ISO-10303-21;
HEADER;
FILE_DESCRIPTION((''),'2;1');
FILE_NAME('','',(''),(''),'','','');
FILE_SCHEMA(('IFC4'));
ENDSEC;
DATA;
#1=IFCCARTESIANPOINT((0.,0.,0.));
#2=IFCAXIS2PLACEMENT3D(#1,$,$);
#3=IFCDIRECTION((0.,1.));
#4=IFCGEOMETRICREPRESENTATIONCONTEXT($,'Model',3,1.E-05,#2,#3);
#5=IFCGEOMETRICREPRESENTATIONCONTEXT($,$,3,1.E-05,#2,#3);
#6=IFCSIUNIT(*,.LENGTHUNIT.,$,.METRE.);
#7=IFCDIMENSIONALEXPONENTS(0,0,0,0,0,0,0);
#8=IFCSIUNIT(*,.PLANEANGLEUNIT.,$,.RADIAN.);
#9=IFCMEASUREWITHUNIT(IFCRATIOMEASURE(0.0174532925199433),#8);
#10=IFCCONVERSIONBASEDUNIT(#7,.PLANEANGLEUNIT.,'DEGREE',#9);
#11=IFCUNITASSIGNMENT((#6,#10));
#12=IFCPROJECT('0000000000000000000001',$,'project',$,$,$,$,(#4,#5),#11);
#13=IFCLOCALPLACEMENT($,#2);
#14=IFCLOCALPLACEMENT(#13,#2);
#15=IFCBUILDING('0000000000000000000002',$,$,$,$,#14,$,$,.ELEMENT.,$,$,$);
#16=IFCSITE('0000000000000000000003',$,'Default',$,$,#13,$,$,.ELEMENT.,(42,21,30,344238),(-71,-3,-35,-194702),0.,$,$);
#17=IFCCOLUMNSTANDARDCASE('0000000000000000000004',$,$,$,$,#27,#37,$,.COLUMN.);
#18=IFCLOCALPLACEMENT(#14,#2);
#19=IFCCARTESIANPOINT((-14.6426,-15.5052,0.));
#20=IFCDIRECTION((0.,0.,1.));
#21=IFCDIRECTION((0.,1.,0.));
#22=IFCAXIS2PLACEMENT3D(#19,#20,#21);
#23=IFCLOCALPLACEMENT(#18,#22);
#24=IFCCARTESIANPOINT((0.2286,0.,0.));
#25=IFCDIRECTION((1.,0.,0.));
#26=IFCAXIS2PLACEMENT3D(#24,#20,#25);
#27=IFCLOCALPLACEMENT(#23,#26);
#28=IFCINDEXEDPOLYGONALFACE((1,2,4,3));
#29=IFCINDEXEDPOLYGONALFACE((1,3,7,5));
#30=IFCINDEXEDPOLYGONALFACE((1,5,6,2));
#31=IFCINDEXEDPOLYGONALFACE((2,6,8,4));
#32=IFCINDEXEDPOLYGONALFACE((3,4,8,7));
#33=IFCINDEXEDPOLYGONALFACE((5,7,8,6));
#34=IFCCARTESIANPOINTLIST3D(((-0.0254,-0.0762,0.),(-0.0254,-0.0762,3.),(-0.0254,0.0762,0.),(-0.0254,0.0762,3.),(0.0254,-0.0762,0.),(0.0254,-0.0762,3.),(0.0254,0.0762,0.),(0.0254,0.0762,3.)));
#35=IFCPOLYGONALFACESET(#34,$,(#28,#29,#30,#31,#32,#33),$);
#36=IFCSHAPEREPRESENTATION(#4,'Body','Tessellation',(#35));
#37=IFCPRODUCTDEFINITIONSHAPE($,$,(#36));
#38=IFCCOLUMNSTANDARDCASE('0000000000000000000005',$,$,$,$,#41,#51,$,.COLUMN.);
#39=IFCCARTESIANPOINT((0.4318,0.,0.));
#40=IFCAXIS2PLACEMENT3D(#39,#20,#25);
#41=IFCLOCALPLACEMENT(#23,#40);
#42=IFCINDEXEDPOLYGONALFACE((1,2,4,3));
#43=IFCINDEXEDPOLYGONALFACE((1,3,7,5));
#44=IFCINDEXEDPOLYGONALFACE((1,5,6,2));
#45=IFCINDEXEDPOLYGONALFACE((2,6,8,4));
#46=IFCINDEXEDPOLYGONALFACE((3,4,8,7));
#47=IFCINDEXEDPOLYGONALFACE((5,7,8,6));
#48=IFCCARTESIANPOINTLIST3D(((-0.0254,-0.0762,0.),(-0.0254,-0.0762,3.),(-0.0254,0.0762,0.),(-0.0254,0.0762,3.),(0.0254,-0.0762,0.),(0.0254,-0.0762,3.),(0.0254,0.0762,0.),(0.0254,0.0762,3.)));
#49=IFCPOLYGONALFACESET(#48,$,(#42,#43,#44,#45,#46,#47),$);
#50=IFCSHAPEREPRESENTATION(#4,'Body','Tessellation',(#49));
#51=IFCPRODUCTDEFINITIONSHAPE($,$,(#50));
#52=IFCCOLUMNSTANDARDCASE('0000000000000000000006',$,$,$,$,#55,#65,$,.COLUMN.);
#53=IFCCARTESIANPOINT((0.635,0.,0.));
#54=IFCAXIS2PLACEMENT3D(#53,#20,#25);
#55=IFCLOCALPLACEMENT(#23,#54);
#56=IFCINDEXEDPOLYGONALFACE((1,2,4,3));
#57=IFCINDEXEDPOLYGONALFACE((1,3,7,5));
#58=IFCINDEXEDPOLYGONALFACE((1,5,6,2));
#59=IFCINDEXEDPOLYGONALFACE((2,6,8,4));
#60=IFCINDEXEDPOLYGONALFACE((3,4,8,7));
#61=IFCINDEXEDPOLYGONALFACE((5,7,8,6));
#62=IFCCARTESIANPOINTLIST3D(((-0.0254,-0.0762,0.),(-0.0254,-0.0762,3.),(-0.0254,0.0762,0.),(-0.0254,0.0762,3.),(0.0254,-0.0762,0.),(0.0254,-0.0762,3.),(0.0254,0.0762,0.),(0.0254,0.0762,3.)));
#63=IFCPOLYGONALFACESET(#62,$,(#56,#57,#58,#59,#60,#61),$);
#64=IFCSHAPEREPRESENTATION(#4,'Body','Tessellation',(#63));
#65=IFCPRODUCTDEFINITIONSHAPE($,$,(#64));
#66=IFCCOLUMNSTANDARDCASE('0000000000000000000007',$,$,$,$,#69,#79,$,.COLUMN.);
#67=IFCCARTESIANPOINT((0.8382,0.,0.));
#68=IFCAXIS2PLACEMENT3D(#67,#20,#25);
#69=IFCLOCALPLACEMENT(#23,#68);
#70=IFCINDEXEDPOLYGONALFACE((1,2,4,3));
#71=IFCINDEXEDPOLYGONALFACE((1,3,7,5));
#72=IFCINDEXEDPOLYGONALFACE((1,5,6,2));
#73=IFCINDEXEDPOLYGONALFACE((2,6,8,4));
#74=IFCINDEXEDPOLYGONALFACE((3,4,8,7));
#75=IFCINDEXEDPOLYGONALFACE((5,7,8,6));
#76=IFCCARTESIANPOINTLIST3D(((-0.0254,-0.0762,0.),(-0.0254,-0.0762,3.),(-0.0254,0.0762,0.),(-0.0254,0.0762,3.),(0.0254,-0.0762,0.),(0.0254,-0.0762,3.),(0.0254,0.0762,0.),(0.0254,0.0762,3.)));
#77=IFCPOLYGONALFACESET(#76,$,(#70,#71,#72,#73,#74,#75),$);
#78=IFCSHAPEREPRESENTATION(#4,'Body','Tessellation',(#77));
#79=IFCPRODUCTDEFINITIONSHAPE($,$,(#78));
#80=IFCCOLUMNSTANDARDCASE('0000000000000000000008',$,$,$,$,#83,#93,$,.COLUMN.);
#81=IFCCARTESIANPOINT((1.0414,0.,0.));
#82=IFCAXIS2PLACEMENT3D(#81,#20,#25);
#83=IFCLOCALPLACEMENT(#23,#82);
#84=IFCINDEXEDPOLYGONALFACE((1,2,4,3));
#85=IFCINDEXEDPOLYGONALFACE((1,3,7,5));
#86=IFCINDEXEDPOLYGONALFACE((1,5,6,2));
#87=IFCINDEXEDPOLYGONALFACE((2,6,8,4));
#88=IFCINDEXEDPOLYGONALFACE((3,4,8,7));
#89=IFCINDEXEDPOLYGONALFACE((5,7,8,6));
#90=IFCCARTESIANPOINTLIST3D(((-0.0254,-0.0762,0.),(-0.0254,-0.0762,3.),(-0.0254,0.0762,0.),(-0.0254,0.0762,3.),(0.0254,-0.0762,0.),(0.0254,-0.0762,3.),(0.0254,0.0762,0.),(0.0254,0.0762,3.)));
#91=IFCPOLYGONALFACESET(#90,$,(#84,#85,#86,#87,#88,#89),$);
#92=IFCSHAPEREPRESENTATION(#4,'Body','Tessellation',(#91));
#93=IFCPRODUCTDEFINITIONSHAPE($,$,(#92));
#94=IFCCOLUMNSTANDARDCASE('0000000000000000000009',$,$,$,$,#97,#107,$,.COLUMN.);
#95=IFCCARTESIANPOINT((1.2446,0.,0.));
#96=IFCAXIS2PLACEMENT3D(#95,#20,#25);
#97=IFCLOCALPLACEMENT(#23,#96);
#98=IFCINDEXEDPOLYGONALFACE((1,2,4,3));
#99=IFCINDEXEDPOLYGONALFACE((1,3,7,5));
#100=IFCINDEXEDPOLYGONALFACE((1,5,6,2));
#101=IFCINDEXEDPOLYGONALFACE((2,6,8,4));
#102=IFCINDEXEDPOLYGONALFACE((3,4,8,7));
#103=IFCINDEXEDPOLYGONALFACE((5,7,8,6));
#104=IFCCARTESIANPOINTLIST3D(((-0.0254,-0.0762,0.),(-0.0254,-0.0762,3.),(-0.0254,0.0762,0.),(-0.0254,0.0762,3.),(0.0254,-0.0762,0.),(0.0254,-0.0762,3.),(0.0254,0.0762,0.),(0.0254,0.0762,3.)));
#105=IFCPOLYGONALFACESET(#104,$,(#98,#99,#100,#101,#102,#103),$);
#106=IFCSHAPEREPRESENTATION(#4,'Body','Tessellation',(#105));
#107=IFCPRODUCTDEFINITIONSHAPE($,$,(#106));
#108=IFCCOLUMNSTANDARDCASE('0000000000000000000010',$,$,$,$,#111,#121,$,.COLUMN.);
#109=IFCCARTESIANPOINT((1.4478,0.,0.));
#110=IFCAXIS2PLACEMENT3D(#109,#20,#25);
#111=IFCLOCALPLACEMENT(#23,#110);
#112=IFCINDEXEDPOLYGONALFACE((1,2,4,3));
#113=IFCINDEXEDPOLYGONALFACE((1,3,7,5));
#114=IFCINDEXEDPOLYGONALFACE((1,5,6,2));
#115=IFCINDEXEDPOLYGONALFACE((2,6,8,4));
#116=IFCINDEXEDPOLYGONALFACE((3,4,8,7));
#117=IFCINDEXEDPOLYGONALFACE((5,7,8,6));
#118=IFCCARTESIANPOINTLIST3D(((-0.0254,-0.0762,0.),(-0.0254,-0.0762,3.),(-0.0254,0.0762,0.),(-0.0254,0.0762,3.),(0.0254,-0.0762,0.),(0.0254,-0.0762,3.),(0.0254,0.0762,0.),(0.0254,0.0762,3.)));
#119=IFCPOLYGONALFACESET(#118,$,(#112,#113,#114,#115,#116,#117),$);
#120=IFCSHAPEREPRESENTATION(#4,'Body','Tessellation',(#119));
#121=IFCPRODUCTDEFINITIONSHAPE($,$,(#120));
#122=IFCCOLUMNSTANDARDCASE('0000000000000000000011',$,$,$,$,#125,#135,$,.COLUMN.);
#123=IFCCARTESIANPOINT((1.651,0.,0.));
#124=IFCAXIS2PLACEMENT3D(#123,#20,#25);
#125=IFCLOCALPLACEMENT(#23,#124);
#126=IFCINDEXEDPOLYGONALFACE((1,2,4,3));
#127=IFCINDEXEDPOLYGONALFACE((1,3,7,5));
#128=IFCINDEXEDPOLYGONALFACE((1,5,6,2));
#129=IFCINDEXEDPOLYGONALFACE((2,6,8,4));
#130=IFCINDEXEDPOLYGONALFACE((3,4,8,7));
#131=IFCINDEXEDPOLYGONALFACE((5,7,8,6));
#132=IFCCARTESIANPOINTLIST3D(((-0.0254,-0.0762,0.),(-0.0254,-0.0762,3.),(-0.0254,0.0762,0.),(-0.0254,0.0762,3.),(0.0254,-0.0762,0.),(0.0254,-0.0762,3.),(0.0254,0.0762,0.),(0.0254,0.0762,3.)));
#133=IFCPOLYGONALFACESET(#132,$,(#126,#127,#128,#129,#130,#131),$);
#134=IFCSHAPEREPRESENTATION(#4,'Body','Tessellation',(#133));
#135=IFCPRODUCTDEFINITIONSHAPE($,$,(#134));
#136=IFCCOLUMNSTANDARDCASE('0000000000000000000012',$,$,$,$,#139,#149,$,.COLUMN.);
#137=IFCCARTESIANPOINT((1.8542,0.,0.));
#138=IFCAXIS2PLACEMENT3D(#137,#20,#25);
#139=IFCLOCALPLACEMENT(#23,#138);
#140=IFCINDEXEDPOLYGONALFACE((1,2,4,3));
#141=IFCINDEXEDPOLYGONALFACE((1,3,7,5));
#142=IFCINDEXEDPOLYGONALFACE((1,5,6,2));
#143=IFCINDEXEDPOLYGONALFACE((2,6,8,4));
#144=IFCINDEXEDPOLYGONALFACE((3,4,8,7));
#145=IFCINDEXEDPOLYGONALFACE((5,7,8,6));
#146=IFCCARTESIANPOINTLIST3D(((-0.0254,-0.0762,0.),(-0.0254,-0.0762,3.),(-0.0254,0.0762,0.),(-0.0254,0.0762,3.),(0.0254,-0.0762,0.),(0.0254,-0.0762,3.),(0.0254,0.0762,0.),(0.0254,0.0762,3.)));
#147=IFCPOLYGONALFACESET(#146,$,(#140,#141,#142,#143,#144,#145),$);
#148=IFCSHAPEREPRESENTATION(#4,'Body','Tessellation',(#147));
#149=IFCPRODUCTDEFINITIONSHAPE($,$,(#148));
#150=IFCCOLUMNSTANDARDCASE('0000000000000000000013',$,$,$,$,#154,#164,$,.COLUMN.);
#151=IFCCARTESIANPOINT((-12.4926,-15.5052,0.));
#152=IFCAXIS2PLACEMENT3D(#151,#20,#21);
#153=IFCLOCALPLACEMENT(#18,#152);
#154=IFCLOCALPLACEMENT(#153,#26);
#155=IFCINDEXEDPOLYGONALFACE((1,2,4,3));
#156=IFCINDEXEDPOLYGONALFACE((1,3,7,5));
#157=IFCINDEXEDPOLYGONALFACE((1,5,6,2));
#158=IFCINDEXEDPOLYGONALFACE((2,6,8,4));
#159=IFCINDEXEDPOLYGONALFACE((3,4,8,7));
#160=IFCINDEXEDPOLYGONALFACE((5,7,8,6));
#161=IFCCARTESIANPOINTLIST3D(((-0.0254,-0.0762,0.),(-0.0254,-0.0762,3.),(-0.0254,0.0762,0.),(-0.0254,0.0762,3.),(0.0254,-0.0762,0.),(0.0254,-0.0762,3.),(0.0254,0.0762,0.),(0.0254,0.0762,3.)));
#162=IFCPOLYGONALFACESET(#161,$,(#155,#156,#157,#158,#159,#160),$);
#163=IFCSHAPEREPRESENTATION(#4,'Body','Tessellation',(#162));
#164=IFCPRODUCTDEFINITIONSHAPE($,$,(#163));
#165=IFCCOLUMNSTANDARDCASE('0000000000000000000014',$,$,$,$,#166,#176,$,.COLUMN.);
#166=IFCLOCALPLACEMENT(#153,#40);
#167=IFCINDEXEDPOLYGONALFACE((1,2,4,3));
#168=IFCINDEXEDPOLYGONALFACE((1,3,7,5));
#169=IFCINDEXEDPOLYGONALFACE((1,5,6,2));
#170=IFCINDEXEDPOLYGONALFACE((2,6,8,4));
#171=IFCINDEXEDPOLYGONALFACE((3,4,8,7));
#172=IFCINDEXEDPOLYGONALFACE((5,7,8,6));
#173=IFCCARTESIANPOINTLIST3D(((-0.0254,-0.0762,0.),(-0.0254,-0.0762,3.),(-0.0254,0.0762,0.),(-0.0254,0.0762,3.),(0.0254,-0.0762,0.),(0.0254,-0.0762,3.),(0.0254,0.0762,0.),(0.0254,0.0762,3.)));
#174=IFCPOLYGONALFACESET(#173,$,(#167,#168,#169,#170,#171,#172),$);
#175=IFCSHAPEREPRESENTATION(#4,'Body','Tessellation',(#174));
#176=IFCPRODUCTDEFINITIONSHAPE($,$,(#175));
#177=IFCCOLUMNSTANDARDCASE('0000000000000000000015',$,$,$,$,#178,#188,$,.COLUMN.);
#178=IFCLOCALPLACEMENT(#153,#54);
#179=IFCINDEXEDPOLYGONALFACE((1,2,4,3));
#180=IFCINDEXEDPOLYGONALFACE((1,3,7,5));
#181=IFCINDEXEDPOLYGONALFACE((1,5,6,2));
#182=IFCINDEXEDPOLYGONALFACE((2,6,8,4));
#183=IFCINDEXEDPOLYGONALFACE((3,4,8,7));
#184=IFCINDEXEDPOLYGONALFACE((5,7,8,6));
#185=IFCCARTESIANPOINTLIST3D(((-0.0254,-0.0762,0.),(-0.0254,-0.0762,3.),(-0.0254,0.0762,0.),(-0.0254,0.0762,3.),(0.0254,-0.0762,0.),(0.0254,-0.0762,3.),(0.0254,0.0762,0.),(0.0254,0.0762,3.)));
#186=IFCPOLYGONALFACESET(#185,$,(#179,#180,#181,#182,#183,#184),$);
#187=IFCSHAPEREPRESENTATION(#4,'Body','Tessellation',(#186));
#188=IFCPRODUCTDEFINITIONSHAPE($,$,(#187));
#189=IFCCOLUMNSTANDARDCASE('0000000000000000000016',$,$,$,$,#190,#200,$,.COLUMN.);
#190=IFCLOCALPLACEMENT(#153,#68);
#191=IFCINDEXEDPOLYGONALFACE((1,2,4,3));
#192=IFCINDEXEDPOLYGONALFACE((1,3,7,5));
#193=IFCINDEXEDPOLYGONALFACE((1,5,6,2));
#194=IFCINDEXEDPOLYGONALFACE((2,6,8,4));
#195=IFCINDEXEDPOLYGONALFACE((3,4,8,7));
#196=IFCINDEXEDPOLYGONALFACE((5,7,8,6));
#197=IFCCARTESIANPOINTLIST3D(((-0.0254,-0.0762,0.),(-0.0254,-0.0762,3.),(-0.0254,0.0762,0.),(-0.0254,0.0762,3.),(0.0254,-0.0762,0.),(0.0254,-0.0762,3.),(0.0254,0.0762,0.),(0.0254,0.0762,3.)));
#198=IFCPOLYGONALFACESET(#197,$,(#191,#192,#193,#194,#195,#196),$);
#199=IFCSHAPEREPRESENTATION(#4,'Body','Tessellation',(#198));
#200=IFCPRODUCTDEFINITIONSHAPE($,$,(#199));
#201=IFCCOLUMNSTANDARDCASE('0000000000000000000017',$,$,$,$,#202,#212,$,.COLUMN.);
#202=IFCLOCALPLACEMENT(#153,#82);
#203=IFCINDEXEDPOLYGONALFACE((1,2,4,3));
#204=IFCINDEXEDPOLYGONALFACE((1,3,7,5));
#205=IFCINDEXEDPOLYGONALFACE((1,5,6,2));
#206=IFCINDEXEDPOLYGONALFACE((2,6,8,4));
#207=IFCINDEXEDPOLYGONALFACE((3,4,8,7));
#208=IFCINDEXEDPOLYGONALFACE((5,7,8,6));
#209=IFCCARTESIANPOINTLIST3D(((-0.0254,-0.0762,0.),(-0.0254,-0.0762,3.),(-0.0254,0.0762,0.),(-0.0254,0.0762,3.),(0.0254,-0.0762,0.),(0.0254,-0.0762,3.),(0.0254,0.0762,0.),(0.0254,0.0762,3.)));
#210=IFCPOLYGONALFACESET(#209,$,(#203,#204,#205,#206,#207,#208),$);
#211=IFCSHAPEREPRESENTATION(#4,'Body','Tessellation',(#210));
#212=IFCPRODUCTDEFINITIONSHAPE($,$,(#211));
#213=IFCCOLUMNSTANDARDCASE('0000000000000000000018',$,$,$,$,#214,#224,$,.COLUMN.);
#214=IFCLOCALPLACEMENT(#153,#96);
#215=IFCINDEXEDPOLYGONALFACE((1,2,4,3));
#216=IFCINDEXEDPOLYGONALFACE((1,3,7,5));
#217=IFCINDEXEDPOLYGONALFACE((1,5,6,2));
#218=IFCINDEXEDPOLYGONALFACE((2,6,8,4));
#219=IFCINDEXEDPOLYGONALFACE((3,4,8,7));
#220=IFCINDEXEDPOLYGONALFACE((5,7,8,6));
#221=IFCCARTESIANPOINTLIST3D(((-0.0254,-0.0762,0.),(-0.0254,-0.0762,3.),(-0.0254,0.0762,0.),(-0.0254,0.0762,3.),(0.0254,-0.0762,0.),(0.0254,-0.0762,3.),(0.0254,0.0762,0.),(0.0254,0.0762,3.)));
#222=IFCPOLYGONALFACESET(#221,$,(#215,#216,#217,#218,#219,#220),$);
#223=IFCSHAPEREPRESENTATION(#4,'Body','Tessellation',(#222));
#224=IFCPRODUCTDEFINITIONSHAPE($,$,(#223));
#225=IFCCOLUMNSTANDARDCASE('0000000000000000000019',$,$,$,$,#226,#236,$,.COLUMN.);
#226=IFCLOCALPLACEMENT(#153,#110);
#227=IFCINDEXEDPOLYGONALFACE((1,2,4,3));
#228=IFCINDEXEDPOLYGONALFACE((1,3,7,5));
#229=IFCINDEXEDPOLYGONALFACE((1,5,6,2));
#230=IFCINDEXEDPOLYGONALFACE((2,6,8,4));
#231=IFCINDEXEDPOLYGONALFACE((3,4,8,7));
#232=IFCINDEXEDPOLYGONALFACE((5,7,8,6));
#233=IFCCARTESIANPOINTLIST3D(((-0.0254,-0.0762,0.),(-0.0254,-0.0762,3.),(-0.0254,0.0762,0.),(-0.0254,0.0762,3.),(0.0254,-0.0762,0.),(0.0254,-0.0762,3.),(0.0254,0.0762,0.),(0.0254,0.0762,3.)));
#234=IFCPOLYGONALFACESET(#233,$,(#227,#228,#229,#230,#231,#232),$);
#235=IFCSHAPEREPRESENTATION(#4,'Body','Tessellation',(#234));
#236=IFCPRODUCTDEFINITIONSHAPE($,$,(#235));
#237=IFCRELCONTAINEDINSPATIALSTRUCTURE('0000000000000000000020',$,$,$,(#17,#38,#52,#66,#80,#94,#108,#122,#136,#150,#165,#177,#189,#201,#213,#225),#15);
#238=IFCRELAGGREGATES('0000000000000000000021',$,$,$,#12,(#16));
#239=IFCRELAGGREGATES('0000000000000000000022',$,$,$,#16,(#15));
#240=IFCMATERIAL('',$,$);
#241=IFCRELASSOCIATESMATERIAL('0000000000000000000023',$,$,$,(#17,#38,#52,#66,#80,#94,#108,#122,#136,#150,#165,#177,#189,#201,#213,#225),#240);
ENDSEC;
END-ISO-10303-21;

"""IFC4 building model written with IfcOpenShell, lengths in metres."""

from ifc_helpers import new_model, entity, si_unit, converted_unit, direction, frame, origin, place, context, project, spatial, rectangle, extrude, material, element, save


model = new_model("IFC4")

# Units and contexts
model_context = context("Model", 3, precision=1e-05, world=origin(), true_north=direction((0.0, 1.0)))
context_of_model = context(None, 3, precision=1e-05, world=origin(), true_north=direction((0.0, 1.0)))
ifc_project = project(units=[si_unit("LENGTHUNIT", "METRE"), converted_unit("PLANEANGLEUNIT", "DEGREE", entity("IfcRatioMeasure", 0.0174532925199433), si_unit("PLANEANGLEUNIT", "RADIAN"), dimensions=[0, 0, 0, 0, 0, 0, 0])], contexts=[model_context, context_of_model])

# Site, building
site_placement = place(None, origin())
site = spatial("IfcSite", under=ifc_project, at=site_placement, Name="Default", CompositionType="ELEMENT", RefLatitude=(42, 21, 30, 344238), RefLongitude=(-71, -3, -35, -194702), RefElevation=0.0)
building_placement = place(site_placement, origin())
building = spatial("IfcBuilding", under=site, at=building_placement, CompositionType="ELEMENT")

# Columns
ifc_material_1 = material(Name="")
placement_1 = place(building_placement, origin())
placement_2 = place(placement_1, frame((-14.6426, -15.5052, 0.0), z_axis=(0.0, 0.0, 1.0), x_axis=(0.0, 1.0, 0.0)))
for number, where, z_axis, x_axis in (
    (1, (0.2286, 0.0, 0.0), (0.0, 0.0, 1.0), (1.0, 0.0, 0.0)),
    (2, (0.4318, 0.0, 0.0), (0.0, 0.0, 1.0), (1.0, 0.0, 0.0)),
    (3, (0.635, 0.0, 0.0), (0.0, 0.0, 1.0), (1.0, 0.0, 0.0)),
    (4, (0.8382, 0.0, 0.0), (0.0, 0.0, 1.0), (1.0, 0.0, 0.0)),
    (5, (1.0414, 0.0, 0.0), (0.0, 0.0, 1.0), (1.0, 0.0, 0.0)),
    (6, (1.2446, 0.0, 0.0), (0.0, 0.0, 1.0), (1.0, 0.0, 0.0)),
    (7, (1.4478, 0.0, 0.0), (0.0, 0.0, 1.0), (1.0, 0.0, 0.0)),
    (8, (1.651, 0.0, 0.0), (0.0, 0.0, 1.0), (1.0, 0.0, 0.0)),
    (9, (1.8542, 0.0, 0.0), (0.0, 0.0, 1.0), (1.0, 0.0, 0.0)),
):
    element("IfcColumnStandardCase", number, at=place(placement_2, frame(where, z_axis=z_axis, x_axis=x_axis)), inside=building, material=ifc_material_1, PredefinedType="COLUMN", context=model_context, shape_type="SweptSolid", body=[
        extrude(rectangle(XDim=0.0508, YDim=0.1524), origin(), (0.0, 0.0, 1.0), 3.0),
    ])
placement_3 = place(placement_1, frame((-12.4926, -15.5052, 0.0), z_axis=(0.0, 0.0, 1.0), x_axis=(0.0, 1.0, 0.0)))
for number, where, z_axis, x_axis in (
    (10, (0.2286, 0.0, 0.0), (0.0, 0.0, 1.0), (1.0, 0.0, 0.0)),
    (11, (0.4318, 0.0, 0.0), (0.0, 0.0, 1.0), (1.0, 0.0, 0.0)),
    (12, (0.635, 0.0, 0.0), (0.0, 0.0, 1.0), (1.0, 0.0, 0.0)),
    (13, (0.8382, 0.0, 0.0), (0.0, 0.0, 1.0), (1.0, 0.0, 0.0)),
    (14, (1.0414, 0.0, 0.0), (0.0, 0.0, 1.0), (1.0, 0.0, 0.0)),
    (15, (1.2446, 0.0, 0.0), (0.0, 0.0, 1.0), (1.0, 0.0, 0.0)),
    (16, (1.4478, 0.0, 0.0), (0.0, 0.0, 1.0), (1.0, 0.0, 0.0)),
):
    element("IfcColumnStandardCase", number, at=place(placement_3, frame(where, z_axis=z_axis, x_axis=x_axis)), inside=building, material=ifc_material_1, PredefinedType="COLUMN", context=model_context, shape_type="SweptSolid", body=[
        extrude(rectangle(XDim=0.0508, YDim=0.1524), origin(), (0.0, 0.0, 1.0), 3.0),
    ])

save(model, "model.ifc")
